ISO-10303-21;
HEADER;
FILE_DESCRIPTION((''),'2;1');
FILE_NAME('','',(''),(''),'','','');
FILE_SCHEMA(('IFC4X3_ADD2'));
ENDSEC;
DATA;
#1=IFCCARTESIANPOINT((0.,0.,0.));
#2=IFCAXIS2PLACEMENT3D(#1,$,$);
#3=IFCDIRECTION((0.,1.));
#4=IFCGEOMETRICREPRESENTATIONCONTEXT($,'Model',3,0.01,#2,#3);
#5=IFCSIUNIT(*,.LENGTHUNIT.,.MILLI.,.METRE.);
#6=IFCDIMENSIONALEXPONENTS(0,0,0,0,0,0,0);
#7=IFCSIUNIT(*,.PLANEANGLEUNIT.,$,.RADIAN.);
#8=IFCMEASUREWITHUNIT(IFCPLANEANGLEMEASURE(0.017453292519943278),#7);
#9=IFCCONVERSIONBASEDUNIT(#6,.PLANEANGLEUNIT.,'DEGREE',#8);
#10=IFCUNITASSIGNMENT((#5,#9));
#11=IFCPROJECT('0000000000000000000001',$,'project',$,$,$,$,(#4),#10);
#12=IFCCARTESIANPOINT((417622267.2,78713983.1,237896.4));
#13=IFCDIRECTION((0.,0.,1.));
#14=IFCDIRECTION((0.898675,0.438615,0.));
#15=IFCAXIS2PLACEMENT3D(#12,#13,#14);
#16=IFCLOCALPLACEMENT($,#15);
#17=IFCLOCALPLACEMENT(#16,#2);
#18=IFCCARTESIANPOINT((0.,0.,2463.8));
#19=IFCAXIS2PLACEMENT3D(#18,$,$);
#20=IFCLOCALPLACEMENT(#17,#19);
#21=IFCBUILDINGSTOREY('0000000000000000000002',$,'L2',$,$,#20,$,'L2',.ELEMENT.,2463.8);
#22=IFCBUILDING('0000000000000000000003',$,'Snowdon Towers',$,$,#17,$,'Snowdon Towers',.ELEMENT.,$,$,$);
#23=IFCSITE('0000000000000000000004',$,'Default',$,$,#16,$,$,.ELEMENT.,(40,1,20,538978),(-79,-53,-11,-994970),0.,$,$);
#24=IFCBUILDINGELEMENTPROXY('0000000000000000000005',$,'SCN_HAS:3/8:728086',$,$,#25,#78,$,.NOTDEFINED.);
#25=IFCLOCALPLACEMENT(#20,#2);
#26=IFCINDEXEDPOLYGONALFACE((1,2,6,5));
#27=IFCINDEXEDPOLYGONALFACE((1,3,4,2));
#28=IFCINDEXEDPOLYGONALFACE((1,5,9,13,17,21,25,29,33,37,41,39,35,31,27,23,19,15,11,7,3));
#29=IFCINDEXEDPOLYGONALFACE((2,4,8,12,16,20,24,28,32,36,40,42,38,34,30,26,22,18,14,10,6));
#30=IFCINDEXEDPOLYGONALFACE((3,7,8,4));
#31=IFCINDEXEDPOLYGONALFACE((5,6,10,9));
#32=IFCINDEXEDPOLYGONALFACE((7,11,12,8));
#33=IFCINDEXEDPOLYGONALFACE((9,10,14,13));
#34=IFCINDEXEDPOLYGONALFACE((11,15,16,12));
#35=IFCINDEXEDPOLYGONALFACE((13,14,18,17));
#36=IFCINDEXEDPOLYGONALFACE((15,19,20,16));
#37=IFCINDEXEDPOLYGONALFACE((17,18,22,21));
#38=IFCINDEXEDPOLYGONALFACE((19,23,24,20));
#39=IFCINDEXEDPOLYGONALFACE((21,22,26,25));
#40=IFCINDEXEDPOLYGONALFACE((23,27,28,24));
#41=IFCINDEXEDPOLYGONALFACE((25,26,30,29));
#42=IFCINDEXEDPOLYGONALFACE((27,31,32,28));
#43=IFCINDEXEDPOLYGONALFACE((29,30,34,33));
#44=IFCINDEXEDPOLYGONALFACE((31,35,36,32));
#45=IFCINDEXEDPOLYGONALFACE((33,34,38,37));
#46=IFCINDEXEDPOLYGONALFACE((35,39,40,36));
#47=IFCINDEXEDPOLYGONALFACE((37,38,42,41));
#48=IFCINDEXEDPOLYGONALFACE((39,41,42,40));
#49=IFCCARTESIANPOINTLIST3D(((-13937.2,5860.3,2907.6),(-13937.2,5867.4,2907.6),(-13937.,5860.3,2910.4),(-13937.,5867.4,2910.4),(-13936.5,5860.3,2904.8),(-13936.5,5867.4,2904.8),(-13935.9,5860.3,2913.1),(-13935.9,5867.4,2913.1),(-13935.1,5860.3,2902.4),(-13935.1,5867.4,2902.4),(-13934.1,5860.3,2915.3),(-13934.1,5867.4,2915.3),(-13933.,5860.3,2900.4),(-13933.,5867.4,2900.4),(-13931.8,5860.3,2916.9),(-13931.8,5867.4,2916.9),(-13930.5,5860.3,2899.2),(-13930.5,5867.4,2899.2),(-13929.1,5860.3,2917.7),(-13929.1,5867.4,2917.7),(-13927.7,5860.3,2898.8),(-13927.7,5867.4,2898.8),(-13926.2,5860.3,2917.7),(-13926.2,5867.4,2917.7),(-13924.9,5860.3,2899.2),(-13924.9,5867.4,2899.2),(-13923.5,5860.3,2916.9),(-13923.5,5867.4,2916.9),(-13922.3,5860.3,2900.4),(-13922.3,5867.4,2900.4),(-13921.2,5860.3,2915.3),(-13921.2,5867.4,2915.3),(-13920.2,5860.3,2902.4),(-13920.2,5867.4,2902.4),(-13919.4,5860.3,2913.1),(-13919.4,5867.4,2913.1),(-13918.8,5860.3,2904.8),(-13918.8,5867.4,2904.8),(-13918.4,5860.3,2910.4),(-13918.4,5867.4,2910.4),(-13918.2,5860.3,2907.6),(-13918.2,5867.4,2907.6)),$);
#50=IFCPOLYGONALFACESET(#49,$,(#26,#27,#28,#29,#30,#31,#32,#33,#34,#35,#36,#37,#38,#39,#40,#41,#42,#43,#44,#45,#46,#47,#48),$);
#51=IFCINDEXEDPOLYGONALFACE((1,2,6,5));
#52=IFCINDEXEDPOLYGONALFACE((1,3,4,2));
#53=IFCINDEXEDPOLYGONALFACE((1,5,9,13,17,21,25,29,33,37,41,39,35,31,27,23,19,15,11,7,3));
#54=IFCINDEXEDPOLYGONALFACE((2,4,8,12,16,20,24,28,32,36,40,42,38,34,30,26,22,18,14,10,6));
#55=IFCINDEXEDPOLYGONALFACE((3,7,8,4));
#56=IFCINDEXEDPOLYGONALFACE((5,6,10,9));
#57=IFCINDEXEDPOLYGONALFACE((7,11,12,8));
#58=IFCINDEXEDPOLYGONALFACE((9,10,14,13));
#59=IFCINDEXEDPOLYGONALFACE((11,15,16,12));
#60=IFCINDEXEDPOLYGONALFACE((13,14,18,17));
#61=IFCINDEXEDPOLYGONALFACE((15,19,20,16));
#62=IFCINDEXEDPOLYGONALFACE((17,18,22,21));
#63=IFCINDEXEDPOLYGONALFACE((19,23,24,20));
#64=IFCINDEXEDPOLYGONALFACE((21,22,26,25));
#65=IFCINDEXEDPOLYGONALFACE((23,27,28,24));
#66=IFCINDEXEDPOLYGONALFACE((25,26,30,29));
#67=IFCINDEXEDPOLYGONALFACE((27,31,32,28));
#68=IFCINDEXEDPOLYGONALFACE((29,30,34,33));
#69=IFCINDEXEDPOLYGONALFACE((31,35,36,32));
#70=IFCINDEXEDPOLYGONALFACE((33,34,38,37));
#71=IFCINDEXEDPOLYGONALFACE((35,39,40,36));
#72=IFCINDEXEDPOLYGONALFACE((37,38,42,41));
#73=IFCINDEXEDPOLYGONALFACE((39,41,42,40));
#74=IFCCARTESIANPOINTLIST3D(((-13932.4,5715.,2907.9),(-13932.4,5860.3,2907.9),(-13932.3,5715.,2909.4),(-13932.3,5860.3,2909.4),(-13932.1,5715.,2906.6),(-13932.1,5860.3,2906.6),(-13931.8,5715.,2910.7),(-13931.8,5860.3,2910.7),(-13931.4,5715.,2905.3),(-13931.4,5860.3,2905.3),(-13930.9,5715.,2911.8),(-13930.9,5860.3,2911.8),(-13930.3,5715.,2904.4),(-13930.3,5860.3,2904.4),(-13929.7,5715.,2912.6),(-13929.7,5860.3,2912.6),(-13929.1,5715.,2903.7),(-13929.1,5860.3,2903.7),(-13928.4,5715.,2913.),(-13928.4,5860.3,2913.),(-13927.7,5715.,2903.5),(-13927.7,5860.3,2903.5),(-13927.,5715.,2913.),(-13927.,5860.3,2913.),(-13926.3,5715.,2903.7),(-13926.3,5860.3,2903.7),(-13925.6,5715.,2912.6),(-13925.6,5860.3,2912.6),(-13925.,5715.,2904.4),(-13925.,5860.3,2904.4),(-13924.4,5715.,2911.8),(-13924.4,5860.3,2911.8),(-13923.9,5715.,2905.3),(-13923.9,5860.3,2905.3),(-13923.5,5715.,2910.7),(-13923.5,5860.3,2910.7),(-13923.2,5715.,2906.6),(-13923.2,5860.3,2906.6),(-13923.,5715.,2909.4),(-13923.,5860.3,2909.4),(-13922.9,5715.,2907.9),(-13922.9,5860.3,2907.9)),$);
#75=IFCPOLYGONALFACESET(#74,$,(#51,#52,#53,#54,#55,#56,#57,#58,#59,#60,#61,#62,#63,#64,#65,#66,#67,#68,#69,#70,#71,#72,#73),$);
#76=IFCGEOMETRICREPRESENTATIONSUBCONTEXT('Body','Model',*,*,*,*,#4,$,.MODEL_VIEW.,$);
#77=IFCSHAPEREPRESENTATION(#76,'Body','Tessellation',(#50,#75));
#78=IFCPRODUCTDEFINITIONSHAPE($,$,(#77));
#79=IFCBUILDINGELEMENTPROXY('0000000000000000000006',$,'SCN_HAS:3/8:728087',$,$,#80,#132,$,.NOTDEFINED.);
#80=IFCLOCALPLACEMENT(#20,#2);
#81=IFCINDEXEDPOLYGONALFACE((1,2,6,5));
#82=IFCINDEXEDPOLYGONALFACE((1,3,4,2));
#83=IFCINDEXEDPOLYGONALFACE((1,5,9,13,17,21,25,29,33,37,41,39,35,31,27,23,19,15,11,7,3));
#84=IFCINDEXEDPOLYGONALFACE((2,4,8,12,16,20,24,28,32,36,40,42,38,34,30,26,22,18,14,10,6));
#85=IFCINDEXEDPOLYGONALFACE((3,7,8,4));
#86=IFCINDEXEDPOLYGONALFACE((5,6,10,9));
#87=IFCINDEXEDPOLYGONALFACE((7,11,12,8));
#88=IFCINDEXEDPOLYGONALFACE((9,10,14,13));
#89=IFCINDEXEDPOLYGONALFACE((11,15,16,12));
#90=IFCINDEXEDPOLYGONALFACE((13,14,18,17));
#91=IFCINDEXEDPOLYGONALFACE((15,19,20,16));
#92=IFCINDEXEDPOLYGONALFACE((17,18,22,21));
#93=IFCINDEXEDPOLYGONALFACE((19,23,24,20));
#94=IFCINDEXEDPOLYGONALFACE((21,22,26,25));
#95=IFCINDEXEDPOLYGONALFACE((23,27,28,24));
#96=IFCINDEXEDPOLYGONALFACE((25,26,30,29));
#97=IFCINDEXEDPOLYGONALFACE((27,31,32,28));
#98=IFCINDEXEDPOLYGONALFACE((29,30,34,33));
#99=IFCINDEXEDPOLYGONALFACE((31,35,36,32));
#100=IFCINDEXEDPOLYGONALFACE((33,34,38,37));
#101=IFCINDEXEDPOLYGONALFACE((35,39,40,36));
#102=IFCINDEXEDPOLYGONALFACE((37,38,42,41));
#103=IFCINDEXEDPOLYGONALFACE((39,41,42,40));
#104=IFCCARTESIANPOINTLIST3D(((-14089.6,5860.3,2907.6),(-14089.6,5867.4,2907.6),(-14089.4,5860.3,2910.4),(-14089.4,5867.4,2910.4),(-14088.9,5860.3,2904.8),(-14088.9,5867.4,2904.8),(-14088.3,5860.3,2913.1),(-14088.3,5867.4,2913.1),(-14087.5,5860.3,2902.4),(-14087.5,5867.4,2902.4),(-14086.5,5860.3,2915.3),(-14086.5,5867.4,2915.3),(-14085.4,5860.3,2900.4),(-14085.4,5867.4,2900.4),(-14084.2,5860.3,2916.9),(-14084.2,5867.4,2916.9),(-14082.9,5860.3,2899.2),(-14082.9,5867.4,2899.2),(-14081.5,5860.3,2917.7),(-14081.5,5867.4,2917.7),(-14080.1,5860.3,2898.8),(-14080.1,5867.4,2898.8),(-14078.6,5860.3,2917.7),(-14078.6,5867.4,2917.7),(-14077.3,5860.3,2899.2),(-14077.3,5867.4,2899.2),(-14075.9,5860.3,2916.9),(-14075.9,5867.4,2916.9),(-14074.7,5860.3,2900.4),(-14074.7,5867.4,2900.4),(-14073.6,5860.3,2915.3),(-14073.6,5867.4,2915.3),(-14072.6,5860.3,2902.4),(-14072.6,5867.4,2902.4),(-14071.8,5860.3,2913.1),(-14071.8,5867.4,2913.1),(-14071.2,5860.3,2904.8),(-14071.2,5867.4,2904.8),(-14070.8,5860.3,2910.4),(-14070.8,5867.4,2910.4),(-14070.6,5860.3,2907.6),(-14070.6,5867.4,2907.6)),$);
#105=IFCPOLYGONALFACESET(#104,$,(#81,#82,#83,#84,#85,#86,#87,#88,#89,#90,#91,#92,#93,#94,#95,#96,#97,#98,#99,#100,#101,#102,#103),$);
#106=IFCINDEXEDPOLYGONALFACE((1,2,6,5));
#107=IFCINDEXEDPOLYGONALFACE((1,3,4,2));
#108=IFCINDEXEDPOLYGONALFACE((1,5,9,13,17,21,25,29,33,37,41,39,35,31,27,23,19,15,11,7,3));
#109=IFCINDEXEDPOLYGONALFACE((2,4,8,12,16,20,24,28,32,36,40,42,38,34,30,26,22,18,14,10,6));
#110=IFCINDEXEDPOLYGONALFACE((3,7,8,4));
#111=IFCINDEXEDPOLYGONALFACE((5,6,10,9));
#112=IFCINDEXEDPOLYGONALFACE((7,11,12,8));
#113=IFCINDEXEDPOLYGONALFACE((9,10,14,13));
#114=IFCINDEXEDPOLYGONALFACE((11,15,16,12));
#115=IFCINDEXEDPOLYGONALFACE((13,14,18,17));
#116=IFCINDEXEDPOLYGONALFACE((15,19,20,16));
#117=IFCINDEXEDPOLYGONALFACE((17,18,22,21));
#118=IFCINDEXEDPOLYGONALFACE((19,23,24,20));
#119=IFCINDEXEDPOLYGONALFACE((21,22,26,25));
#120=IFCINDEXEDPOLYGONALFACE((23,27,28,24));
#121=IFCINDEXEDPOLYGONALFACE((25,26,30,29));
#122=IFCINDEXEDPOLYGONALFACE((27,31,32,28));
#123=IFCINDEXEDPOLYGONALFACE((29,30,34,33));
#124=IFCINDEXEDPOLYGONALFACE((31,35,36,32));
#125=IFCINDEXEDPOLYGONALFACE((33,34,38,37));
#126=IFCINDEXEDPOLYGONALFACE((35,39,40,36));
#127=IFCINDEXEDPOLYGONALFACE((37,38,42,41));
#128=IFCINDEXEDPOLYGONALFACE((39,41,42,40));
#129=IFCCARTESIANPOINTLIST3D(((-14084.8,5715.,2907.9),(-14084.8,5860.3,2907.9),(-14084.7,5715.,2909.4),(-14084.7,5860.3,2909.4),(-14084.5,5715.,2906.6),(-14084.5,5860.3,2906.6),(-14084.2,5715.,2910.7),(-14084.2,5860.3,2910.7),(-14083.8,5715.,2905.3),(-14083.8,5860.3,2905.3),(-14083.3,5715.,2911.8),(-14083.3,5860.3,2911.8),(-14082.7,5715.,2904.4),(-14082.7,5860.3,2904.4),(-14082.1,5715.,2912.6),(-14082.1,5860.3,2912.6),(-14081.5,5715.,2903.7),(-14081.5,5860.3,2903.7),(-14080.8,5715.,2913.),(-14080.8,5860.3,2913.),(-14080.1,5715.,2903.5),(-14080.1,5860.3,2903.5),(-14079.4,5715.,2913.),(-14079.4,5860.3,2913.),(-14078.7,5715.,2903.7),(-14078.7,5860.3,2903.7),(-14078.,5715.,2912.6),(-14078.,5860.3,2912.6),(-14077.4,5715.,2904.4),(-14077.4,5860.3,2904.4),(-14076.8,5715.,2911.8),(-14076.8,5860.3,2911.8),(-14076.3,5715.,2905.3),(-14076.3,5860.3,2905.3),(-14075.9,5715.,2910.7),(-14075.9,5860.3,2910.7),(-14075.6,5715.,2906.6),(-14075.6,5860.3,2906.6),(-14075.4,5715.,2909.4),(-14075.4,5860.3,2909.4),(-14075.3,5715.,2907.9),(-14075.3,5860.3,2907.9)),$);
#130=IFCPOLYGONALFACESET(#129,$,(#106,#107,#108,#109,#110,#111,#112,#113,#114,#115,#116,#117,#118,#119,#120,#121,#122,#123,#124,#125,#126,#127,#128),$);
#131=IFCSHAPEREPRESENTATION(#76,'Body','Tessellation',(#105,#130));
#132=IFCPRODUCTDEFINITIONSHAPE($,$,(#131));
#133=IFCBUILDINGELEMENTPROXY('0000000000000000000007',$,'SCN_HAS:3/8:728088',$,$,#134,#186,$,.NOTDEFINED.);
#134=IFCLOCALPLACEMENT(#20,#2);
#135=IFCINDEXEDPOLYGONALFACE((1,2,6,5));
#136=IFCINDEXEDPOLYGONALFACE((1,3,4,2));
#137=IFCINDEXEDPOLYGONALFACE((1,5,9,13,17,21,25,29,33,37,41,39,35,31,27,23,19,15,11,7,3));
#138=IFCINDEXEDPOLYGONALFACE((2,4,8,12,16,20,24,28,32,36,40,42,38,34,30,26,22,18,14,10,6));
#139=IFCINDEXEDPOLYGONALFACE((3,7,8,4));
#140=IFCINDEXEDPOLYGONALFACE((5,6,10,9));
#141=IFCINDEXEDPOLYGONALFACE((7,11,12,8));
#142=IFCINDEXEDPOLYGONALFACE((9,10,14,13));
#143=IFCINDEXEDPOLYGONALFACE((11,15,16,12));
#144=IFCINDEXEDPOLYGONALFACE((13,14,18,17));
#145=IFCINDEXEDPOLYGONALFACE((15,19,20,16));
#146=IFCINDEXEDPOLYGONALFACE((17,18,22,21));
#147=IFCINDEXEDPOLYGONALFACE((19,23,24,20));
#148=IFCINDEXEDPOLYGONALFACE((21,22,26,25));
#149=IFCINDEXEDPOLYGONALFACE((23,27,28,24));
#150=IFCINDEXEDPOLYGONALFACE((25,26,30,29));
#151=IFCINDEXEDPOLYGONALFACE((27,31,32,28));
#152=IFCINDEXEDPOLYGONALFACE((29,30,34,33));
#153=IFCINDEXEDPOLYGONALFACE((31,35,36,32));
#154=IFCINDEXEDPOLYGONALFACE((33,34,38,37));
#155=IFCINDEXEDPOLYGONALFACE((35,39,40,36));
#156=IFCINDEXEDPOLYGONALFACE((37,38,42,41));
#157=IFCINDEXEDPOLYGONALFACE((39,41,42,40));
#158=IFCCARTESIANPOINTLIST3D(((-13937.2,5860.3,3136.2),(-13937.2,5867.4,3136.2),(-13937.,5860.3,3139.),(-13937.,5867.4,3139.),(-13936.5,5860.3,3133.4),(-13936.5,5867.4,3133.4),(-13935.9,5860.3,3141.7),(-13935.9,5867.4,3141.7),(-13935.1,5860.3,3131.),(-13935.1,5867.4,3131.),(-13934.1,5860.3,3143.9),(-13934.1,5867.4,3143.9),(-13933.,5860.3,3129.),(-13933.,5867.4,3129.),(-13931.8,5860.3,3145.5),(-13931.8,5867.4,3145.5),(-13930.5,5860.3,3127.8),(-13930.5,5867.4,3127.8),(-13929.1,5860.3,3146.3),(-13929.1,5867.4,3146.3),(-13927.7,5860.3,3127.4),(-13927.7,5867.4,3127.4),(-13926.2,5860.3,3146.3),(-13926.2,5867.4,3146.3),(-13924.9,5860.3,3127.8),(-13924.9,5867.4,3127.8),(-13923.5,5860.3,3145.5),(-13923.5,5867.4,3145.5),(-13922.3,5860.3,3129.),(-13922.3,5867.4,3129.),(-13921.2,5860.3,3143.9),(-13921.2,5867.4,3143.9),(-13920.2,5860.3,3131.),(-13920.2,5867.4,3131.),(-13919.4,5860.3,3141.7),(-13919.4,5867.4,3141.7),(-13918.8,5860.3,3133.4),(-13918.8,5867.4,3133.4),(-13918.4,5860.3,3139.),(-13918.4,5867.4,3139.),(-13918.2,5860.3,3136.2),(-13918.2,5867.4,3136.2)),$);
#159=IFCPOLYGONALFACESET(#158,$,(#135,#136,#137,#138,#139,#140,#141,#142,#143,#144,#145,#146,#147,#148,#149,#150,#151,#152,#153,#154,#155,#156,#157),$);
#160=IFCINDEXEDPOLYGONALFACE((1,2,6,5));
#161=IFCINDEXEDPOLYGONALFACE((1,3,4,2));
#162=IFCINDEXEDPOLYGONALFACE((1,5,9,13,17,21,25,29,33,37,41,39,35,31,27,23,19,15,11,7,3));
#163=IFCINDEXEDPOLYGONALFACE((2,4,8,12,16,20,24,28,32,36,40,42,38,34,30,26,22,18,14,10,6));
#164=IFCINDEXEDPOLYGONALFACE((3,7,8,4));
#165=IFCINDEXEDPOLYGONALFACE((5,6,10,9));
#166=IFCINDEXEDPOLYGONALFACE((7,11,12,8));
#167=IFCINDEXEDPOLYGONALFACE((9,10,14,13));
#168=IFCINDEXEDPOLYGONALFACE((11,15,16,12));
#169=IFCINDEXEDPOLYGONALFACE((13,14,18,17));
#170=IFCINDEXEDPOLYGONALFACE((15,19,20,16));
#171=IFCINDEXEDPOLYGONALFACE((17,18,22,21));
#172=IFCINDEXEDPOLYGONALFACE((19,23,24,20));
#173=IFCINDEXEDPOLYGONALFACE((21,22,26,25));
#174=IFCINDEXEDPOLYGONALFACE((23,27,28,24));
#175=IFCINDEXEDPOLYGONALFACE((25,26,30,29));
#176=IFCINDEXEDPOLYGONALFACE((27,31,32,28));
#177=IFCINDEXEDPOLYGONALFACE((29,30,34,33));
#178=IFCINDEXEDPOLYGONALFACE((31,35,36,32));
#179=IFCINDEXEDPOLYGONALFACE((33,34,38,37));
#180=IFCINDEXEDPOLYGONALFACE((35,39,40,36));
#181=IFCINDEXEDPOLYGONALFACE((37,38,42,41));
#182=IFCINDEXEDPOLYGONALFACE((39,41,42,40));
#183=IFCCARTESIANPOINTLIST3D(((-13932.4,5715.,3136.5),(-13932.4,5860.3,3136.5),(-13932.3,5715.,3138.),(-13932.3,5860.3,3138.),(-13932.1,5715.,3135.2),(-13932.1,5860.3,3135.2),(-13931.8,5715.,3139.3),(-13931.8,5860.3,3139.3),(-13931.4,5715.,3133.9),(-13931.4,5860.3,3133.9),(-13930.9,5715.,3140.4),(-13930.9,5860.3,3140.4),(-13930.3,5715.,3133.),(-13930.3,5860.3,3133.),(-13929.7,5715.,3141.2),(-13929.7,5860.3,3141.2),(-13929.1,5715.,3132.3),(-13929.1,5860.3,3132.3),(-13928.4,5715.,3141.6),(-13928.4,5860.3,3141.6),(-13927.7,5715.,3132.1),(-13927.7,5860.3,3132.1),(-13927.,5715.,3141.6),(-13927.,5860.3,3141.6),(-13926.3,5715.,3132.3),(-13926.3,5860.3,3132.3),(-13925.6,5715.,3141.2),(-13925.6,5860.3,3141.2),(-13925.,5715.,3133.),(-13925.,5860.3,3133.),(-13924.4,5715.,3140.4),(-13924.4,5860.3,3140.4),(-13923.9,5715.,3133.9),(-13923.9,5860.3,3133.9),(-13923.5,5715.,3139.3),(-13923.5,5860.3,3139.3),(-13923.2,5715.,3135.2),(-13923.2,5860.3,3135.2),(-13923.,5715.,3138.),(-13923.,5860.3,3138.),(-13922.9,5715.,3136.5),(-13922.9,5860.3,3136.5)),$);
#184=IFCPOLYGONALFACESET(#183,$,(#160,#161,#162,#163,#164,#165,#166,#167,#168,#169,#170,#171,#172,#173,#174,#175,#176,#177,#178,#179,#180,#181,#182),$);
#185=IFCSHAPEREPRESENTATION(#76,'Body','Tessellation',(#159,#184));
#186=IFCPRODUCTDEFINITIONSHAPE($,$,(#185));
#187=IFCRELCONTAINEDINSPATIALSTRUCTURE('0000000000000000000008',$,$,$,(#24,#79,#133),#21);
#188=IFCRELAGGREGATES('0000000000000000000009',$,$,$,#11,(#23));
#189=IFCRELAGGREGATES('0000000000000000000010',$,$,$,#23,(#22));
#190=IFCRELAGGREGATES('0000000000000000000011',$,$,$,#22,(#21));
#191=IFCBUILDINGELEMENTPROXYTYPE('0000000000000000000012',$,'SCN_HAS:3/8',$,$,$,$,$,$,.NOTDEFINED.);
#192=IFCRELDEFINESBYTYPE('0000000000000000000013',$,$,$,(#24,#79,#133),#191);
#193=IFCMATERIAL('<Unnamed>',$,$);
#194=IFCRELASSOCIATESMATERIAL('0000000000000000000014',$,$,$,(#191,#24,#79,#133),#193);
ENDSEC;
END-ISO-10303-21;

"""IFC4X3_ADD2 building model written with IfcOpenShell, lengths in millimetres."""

from ifc_helpers import new_model, entity, si_unit, converted_unit, direction, frame, frame_2d, origin, place, context, subcontext, project, spatial, circle, extrude, source, transform, mapped, material, type_object, type_shapes, element, save


model = new_model("IFC4X3_ADD2")

# Units and contexts
model_context = context("Model", 3, precision=0.01, world=origin(), true_north=direction((0.0, 1.0)))
body_context = subcontext(model_context, "Body", "Model", "MODEL_VIEW")
ifc_project = project(units=[si_unit("LENGTHUNIT", "METRE", prefix="MILLI"), converted_unit("PLANEANGLEUNIT", "DEGREE", entity("IfcPlaneAngleMeasure", 0.017453292519943278), si_unit("PLANEANGLEUNIT", "RADIAN"), dimensions=[0, 0, 0, 0, 0, 0, 0])], contexts=[model_context])

# Site, building, storey
site_placement = place(None, frame((417622267.2, 78713983.1, 237896.4), z_axis=(0.0, 0.0, 1.0), x_axis=(0.898675, 0.438615, 0.0)))
site = spatial("IfcSite", under=ifc_project, at=site_placement, Name="Default", CompositionType="ELEMENT", RefLatitude=(40, 1, 20, 538978), RefLongitude=(-79, -53, -11, -994970), RefElevation=0.0)
building_placement = place(site_placement, origin())
building = spatial("IfcBuilding", under=site, at=building_placement, Name="Snowdon Towers", LongName="Snowdon Towers", CompositionType="ELEMENT")
storey_placement = place(building_placement, frame((0.0, 0.0, 2463.8)))
storey = spatial("IfcBuildingStorey", under=building, at=storey_placement, Name="L2", LongName="L2", CompositionType="ELEMENT", Elevation=2463.8)

# Building element proxies
ifc_material_1 = material(Name="<Unnamed>")
building_element_proxy_type_1 = type_object("IfcBuildingElementProxyType", Name="SCN_HAS:3/8", PredefinedType="NOTDEFINED", material=ifc_material_1)
shared_shape_1 = source(origin(), body_context, "Body", "SweptSolid", [
    extrude(circle(Radius=9.5, at=frame_2d((0.0, 0.0), x_axis=(1.0, 0.0))), frame((0.0, 0.0, -152.4), z_axis=(0.0, 0.0, 1.0), x_axis=(0.0, -1.0, 0.0)), (0.0, 0.0, 1.0), 7.1),
    extrude(circle(Radius=4.8, at=frame_2d((0.0, 0.0), x_axis=(1.0, 0.0))), frame((0.0, 0.0, -145.3), z_axis=(0.0, 0.0, 1.0), x_axis=(0.0, -1.0, 0.0)), (0.0, 0.0, 1.0), 145.3),
])
type_shapes(building_element_proxy_type_1, [shared_shape_1])
for number, where, z_axis, x_axis, name in (
    (1, (-13927.7, 5715.0, 2908.3), (0.0, -1.0, 0.0), (1.0, 0.0, 0.0), "SCN_HAS:3/8:728086"),
    (2, (-14080.1, 5715.0, 2908.3), (0.0, -1.0, 0.0), (1.0, 0.0, 0.0), "SCN_HAS:3/8:728087"),
    (3, (-13927.7, 5715.0, 3136.9), (0.0, -1.0, 0.0), (1.0, 0.0, 0.0), "SCN_HAS:3/8:728088"),
):
    element("IfcBuildingElementProxy", number, at=place(storey_placement, frame(where, z_axis=z_axis, x_axis=x_axis)), inside=storey, type_object=building_element_proxy_type_1, material=ifc_material_1, Name=name, PredefinedType="NOTDEFINED", context=body_context, shape_type="MappedRepresentation", body=[
        mapped(shared_shape_1, transform((0.0, 0.0, 0.0), scale=1.0)),
    ])

save(model, "model.ifc")
